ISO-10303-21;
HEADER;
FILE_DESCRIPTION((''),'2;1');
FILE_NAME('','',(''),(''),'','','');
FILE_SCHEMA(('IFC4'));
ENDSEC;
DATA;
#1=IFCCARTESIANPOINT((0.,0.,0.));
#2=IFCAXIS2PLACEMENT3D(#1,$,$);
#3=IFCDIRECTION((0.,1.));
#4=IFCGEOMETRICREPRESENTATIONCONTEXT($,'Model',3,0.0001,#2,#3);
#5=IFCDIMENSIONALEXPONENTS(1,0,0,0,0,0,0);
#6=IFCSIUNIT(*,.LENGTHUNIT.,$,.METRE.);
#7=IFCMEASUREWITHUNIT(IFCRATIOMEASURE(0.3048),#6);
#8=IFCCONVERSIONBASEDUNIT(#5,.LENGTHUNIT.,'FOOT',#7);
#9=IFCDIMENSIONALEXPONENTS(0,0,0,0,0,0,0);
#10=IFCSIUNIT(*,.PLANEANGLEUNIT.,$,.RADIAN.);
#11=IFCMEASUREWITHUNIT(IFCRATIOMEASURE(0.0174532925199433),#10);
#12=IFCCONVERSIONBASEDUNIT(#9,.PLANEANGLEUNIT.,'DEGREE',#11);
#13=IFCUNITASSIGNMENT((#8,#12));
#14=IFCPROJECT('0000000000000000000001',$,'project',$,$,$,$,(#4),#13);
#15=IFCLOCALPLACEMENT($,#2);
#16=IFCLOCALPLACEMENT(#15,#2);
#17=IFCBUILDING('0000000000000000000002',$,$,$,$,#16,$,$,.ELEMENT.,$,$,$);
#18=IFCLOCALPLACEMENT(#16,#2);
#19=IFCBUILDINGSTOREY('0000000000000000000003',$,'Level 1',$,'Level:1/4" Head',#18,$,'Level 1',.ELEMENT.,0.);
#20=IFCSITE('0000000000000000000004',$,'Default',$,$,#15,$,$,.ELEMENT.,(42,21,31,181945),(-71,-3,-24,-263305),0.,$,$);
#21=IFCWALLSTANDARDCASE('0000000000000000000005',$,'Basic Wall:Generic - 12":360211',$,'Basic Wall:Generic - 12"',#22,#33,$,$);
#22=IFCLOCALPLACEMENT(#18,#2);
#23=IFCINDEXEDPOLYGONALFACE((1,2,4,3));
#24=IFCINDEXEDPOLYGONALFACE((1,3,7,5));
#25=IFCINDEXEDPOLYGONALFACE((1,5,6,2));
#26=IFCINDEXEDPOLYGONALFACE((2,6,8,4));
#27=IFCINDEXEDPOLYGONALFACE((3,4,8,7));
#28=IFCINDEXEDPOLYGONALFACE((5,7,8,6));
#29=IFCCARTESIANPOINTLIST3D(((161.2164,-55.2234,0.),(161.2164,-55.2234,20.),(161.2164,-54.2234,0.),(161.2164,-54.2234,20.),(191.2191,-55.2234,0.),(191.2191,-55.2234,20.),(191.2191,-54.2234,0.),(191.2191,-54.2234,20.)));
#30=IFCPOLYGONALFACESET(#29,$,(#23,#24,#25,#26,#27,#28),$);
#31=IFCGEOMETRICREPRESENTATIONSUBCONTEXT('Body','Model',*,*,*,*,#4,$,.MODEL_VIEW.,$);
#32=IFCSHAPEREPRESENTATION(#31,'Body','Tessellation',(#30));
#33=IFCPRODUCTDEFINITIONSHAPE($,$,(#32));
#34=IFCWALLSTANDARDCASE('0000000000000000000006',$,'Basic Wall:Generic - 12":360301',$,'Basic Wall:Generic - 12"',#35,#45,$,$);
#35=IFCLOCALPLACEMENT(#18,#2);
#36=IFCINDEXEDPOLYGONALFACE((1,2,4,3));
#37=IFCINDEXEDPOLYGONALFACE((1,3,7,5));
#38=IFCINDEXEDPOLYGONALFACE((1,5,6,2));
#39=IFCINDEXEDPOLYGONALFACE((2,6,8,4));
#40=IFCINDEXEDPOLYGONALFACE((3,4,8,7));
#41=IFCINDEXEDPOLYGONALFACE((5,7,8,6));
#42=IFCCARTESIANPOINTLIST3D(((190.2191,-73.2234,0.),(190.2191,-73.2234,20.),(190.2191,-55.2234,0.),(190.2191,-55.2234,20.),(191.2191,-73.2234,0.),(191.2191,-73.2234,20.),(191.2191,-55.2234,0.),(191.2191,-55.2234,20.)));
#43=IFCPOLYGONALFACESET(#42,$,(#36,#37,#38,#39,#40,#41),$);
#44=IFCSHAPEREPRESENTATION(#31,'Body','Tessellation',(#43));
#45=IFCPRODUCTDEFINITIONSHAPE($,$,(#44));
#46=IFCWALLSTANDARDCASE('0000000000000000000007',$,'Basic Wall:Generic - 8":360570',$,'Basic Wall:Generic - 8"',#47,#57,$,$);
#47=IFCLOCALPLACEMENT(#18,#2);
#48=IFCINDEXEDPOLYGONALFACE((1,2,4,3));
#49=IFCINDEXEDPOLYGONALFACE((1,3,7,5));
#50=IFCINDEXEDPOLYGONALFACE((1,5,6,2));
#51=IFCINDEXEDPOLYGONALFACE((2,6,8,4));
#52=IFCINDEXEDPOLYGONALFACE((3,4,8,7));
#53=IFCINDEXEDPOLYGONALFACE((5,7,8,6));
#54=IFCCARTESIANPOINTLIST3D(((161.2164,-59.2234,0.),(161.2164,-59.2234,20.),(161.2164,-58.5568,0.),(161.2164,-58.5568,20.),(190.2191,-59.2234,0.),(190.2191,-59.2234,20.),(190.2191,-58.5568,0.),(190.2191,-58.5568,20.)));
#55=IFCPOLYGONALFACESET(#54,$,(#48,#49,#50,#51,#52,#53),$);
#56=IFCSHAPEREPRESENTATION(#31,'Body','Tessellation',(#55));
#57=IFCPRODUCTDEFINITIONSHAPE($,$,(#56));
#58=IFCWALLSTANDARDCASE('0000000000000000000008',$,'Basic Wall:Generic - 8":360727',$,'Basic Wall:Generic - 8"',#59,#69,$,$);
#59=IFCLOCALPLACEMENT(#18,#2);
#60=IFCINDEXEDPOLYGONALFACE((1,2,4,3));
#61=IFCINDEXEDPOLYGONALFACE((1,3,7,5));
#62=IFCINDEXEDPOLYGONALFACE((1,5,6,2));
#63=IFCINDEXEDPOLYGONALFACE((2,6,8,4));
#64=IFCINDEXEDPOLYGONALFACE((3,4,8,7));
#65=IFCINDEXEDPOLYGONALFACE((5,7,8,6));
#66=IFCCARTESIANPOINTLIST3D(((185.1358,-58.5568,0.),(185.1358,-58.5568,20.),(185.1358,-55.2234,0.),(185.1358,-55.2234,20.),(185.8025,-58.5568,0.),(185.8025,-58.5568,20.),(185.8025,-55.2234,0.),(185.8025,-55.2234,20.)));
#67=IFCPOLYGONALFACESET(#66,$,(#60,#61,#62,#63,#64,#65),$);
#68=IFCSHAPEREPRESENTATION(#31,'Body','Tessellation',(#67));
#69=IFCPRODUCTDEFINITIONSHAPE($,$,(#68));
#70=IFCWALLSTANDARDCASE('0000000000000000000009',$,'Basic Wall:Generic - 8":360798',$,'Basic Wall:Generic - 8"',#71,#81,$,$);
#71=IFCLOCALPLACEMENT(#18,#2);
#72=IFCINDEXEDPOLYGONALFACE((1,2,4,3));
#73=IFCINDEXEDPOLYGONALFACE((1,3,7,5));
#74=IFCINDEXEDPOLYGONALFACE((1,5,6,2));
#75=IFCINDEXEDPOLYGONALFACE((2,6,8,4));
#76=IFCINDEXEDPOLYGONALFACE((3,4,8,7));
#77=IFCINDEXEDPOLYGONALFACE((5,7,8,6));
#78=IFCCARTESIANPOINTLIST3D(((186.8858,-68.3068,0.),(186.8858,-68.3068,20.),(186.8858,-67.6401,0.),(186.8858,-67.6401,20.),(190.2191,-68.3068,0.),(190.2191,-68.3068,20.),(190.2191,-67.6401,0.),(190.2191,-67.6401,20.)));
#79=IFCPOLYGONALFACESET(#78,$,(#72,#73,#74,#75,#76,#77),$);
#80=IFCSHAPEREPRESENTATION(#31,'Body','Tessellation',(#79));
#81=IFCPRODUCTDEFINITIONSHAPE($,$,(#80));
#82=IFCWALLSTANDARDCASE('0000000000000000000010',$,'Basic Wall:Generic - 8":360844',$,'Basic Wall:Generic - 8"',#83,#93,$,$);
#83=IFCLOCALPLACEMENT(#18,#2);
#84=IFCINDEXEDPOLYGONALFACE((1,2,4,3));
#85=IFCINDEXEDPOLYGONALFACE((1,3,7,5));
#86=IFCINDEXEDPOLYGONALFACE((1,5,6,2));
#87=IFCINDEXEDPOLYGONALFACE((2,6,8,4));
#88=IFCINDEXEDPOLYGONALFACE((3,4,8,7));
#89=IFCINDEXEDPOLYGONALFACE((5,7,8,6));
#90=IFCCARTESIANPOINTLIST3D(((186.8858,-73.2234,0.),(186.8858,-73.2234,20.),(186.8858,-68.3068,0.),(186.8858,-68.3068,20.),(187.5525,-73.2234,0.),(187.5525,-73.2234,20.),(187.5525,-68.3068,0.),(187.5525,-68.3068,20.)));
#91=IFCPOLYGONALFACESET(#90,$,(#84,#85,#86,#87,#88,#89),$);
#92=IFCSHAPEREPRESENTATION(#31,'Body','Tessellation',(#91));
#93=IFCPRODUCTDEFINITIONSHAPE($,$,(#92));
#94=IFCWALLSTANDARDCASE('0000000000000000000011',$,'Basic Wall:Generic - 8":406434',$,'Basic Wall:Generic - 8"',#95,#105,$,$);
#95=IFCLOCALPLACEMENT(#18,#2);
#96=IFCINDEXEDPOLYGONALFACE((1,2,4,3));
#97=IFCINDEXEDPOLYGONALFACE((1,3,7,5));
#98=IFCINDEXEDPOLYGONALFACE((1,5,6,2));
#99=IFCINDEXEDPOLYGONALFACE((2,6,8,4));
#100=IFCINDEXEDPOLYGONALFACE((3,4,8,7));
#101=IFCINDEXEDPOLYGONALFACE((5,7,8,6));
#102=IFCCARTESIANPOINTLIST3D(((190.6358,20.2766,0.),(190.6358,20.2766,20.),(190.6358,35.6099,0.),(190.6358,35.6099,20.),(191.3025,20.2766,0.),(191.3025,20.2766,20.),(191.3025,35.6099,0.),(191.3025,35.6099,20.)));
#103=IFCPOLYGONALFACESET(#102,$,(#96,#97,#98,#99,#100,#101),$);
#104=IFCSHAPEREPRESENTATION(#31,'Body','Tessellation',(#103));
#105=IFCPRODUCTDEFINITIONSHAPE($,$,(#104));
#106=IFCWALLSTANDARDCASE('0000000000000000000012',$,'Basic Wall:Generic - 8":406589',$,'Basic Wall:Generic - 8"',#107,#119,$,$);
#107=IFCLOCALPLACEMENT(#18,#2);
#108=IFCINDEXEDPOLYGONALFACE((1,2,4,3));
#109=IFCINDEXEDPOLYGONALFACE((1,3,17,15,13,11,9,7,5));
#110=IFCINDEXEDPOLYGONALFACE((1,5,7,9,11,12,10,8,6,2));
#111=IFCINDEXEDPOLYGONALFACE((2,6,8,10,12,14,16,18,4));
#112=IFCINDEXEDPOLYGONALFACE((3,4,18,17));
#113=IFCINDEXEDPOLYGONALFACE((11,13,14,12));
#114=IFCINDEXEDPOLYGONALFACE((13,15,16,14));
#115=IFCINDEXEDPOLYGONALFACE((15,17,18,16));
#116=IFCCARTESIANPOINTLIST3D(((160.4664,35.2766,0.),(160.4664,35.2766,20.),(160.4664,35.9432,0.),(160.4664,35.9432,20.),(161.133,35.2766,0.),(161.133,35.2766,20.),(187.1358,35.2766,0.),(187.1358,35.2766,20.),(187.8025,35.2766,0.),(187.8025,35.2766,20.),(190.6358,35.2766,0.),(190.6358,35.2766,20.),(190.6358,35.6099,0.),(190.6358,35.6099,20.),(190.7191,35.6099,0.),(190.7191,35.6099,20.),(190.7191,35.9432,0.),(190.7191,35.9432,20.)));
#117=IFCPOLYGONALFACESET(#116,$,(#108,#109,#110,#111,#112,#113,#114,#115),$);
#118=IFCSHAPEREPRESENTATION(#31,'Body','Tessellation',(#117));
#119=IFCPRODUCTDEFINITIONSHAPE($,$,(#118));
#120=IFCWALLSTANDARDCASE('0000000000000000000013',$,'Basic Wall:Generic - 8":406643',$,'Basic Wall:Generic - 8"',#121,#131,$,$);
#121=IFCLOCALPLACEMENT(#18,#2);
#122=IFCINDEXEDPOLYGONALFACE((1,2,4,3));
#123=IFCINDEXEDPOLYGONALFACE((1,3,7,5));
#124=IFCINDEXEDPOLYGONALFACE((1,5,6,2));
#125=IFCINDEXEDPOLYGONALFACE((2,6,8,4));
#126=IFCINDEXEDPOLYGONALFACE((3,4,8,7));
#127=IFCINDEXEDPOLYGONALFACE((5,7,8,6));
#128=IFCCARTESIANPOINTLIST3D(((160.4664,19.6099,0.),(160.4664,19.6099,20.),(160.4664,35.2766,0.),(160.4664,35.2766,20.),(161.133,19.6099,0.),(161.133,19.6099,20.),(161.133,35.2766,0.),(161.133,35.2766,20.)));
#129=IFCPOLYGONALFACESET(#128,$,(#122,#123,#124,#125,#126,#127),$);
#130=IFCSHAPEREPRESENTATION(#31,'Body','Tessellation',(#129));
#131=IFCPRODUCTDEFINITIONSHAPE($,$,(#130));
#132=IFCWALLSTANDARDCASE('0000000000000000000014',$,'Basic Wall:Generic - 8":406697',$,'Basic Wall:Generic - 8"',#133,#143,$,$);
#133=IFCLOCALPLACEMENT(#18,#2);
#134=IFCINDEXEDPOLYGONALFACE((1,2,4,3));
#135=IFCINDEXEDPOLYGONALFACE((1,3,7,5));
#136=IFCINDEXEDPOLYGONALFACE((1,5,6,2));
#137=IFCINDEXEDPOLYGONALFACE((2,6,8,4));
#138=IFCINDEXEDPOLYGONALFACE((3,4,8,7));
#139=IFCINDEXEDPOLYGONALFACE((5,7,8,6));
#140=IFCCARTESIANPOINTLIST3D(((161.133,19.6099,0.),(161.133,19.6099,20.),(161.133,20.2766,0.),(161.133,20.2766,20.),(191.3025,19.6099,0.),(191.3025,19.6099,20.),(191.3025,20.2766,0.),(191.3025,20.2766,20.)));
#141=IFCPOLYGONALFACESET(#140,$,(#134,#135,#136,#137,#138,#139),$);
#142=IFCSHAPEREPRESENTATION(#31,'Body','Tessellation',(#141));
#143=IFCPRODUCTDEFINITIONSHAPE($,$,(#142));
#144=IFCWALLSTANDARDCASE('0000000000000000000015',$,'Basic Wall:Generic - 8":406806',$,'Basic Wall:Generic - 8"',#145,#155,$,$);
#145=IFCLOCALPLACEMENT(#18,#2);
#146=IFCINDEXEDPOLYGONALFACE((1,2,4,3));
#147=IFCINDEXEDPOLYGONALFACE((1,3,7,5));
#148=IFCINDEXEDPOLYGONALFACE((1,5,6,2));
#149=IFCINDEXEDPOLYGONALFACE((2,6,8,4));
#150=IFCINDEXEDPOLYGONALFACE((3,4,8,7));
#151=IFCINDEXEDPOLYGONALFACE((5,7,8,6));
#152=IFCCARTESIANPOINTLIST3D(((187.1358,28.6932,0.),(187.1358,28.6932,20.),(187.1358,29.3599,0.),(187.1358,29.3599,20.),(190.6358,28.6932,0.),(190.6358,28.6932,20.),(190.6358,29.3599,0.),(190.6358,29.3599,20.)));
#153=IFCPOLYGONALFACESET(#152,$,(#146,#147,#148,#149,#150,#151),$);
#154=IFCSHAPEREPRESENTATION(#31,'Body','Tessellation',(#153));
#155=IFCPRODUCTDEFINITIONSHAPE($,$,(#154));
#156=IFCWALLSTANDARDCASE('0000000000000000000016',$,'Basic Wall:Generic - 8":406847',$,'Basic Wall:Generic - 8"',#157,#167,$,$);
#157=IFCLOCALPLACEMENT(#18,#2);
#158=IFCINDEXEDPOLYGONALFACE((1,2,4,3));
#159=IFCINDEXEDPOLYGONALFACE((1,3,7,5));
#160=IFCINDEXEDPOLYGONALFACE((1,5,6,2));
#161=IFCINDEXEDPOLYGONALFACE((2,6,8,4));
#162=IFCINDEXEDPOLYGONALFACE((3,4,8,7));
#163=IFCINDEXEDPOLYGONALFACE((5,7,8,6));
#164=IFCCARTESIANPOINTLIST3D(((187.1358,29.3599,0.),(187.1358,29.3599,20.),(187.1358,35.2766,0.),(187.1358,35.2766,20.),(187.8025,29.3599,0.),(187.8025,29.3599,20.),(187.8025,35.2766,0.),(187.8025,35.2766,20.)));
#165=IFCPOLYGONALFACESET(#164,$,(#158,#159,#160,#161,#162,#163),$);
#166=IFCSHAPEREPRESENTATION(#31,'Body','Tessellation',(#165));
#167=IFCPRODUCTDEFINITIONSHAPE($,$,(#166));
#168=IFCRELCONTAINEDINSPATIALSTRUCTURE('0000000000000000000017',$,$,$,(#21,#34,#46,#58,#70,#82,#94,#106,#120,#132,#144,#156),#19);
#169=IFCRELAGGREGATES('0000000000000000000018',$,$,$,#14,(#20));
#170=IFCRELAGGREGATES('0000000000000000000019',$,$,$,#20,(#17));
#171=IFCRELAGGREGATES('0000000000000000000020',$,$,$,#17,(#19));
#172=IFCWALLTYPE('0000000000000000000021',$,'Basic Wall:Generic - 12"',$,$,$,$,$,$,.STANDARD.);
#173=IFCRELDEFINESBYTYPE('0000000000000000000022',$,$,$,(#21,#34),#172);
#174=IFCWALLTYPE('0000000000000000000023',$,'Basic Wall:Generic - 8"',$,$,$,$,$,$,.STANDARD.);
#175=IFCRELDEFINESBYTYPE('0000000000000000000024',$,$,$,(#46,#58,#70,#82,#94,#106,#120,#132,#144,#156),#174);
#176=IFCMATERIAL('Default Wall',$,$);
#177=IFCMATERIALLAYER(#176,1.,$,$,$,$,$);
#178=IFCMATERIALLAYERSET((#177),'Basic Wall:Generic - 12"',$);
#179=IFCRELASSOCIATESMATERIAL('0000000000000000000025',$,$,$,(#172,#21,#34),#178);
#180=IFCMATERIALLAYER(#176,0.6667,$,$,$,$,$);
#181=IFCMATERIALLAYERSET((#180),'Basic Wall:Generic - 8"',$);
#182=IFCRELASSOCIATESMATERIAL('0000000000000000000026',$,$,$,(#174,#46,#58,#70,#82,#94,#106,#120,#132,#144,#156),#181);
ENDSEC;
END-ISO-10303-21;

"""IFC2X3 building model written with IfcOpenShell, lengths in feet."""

from ifc_helpers import new_model, entity, si_unit, converted_unit, direction, frame, frame_2d, origin, place, context, subcontext, project, spatial, polyline, rectangle, outline, extrude, material, layer, layer_set, layer_usage, type_object, element, save


model = new_model("IFC2X3")

# Units and contexts
model_context = context("Model", 3, precision=0.0001, world=origin(), true_north=direction((0.0, 1.0)))
body_context = subcontext(model_context, "Body", "Model", "MODEL_VIEW")
ifc_project = project(units=[converted_unit("LENGTHUNIT", "FOOT", entity("IfcRatioMeasure", 0.3048), si_unit("LENGTHUNIT", "METRE"), dimensions=[1, 0, 0, 0, 0, 0, 0]), converted_unit("PLANEANGLEUNIT", "DEGREE", entity("IfcRatioMeasure", 0.0174532925199433), si_unit("PLANEANGLEUNIT", "RADIAN"), dimensions=[0, 0, 0, 0, 0, 0, 0])], contexts=[model_context])

# Site, building, storey
site_placement = place(None, origin())
site = spatial("IfcSite", under=ifc_project, at=site_placement, Name="Default", CompositionType="ELEMENT", RefLatitude=(42, 21, 31, 181945), RefLongitude=(-71, -3, -24, -263305), RefElevation=0.0)
building_placement = place(site_placement, origin())
building = spatial("IfcBuilding", under=site, at=building_placement, CompositionType="ELEMENT")
storey_placement = place(building_placement, origin())
storey = spatial("IfcBuildingStorey", under=building, at=storey_placement, Name="Level 1", ObjectType="Level:1/4\" Head", LongName="Level 1", CompositionType="ELEMENT", Elevation=0.0)

# Walls
ifc_material = material(Name="Default Wall")
ifc_layer_1 = layer(ifc_material, 1.0)
ifc_layer_set_1 = layer_set([ifc_layer_1], Name="Basic Wall:Generic - 12\"")
ifc_layer_usage_1 = layer_usage(ifc_layer_set_1, "AXIS2", "NEGATIVE", 0.5)
wall_type_1 = type_object("IfcWallType", Name="Basic Wall:Generic - 12\"", PredefinedType="STANDARD", material=ifc_layer_set_1)
wall_1_placement = place(storey_placement, frame((161.2164, -54.7234, 0.0)))
element("IfcWallStandardCase", 1, at=wall_1_placement, inside=storey, type_object=wall_type_1, material=ifc_layer_usage_1, Name="Basic Wall:Generic - 12\":360211", ObjectType="Basic Wall:Generic - 12\"", context=body_context, shape_type="SweptSolid", body=[
    extrude(rectangle(XDim=30.0028, YDim=1.0, at=frame_2d((15.0014, 0.0), x_axis=(-1.0, 0.0))), origin(), (0.0, 0.0, 1.0), 20.0),
])
ifc_layer_usage_2 = layer_usage(ifc_layer_set_1, "AXIS2", "NEGATIVE", 0.5)
wall_2_placement = place(storey_placement, frame((190.7191, -55.2234, 0.0), z_axis=(0.0, 0.0, 1.0), x_axis=(0.0, -1.0, 0.0)))
element("IfcWallStandardCase", 2, at=wall_2_placement, inside=storey, type_object=wall_type_1, material=ifc_layer_usage_2, Name="Basic Wall:Generic - 12\":360301", ObjectType="Basic Wall:Generic - 12\"", context=body_context, shape_type="SweptSolid", body=[
    extrude(rectangle(XDim=18.0, YDim=1.0, at=frame_2d((9.0, 0.0), x_axis=(-1.0, 0.0))), origin(), (0.0, 0.0, 1.0), 20.0),
])
ifc_layer_2 = layer(ifc_material, 0.6667)
ifc_layer_set_2 = layer_set([ifc_layer_2], Name="Basic Wall:Generic - 8\"")
ifc_layer_usage_3 = layer_usage(ifc_layer_set_2, "AXIS2", "NEGATIVE", 0.3333)
wall_type_2 = type_object("IfcWallType", Name="Basic Wall:Generic - 8\"", PredefinedType="STANDARD", material=ifc_layer_set_2)
wall_3_placement = place(storey_placement, frame((161.2164, -58.8901, 0.0)))
element("IfcWallStandardCase", 3, at=wall_3_placement, inside=storey, type_object=wall_type_2, material=ifc_layer_usage_3, Name="Basic Wall:Generic - 8\":360570", ObjectType="Basic Wall:Generic - 8\"", context=body_context, shape_type="SweptSolid", body=[
    extrude(rectangle(XDim=29.0028, YDim=0.6667, at=frame_2d((14.5014, 0.0), x_axis=(-1.0, 0.0))), origin(), (0.0, 0.0, 1.0), 20.0),
])
ifc_layer_usage_4 = layer_usage(ifc_layer_set_2, "AXIS2", "NEGATIVE", 0.3333)
wall_4_placement = place(storey_placement, frame((185.4691, -55.2234, 0.0), z_axis=(0.0, 0.0, 1.0), x_axis=(0.0, -1.0, 0.0)))
element("IfcWallStandardCase", 4, at=wall_4_placement, inside=storey, type_object=wall_type_2, material=ifc_layer_usage_4, Name="Basic Wall:Generic - 8\":360727", ObjectType="Basic Wall:Generic - 8\"", context=body_context, shape_type="SweptSolid", body=[
    extrude(rectangle(XDim=3.3333, YDim=0.6667, at=frame_2d((1.6667, 0.0), x_axis=(-1.0, 0.0))), origin(), (0.0, 0.0, 1.0), 20.0),
])
ifc_layer_usage_5 = layer_usage(ifc_layer_set_2, "AXIS2", "NEGATIVE", 0.3333)
wall_5_placement = place(storey_placement, frame((190.2191, -67.9734, 0.0), z_axis=(0.0, 0.0, 1.0), x_axis=(-1.0, 0.0, 0.0)))
element("IfcWallStandardCase", 5, at=wall_5_placement, inside=storey, type_object=wall_type_2, material=ifc_layer_usage_5, Name="Basic Wall:Generic - 8\":360798", ObjectType="Basic Wall:Generic - 8\"", context=body_context, shape_type="SweptSolid", body=[
    extrude(rectangle(XDim=3.3333, YDim=0.6667, at=frame_2d((1.6667, 0.0), x_axis=(-1.0, 0.0))), origin(), (0.0, 0.0, 1.0), 20.0),
])
ifc_layer_usage_6 = layer_usage(ifc_layer_set_2, "AXIS2", "NEGATIVE", 0.3333)
wall_6_placement = place(storey_placement, frame((187.2191, -68.3068, 0.0), z_axis=(0.0, 0.0, 1.0), x_axis=(0.0, -1.0, 0.0)))
element("IfcWallStandardCase", 6, at=wall_6_placement, inside=storey, type_object=wall_type_2, material=ifc_layer_usage_6, Name="Basic Wall:Generic - 8\":360844", ObjectType="Basic Wall:Generic - 8\"", context=body_context, shape_type="SweptSolid", body=[
    extrude(rectangle(XDim=4.9167, YDim=0.6667, at=frame_2d((2.4583, 0.0), x_axis=(-1.0, 0.0))), origin(), (0.0, 0.0, 1.0), 20.0),
])
ifc_layer_usage_7 = layer_usage(ifc_layer_set_2, "AXIS2", "NEGATIVE", 0.3333)
wall_7_placement = place(storey_placement, frame((190.9691, 20.2766, 0.0), z_axis=(0.0, 0.0, 1.0), x_axis=(0.0, 1.0, 0.0)))
element("IfcWallStandardCase", 7, at=wall_7_placement, inside=storey, type_object=wall_type_2, material=ifc_layer_usage_7, Name="Basic Wall:Generic - 8\":406434", ObjectType="Basic Wall:Generic - 8\"", context=body_context, shape_type="SweptSolid", body=[
    extrude(rectangle(XDim=15.3333, YDim=0.6667, at=frame_2d((7.6667, 0.0), x_axis=(-1.0, 0.0))), origin(), (0.0, 0.0, 1.0), 20.0),
])
ifc_layer_usage_8 = layer_usage(ifc_layer_set_2, "AXIS2", "NEGATIVE", 0.3333)
wall_8_placement = place(storey_placement, frame((190.7191, 35.6099, 0.0), z_axis=(0.0, 0.0, 1.0), x_axis=(-1.0, 0.0, 0.0)))
element("IfcWallStandardCase", 8, at=wall_8_placement, inside=storey, type_object=wall_type_2, material=ifc_layer_usage_8, Name="Basic Wall:Generic - 8\":406589", ObjectType="Basic Wall:Generic - 8\"", context=body_context, shape_type="SweptSolid", body=[
    extrude(outline(polyline([(30.2528, -0.3333), (30.2528, 0.3333), (29.5861, 0.3333), (3.5833, 0.3333), (2.9167, 0.3333), (0.0833, 0.3333), (0.0833, 0.0), (0.0, 0.0), (0.0, -0.3333), (30.2528, -0.3333)])), origin(), (0.0, 0.0, 1.0), 20.0),
])
ifc_layer_usage_9 = layer_usage(ifc_layer_set_2, "AXIS2", "NEGATIVE", 0.3333)
wall_9_placement = place(storey_placement, frame((160.7997, 35.2766, 0.0), z_axis=(0.0, 0.0, 1.0), x_axis=(0.0, -1.0, 0.0)))
element("IfcWallStandardCase", 9, at=wall_9_placement, inside=storey, type_object=wall_type_2, material=ifc_layer_usage_9, Name="Basic Wall:Generic - 8\":406643", ObjectType="Basic Wall:Generic - 8\"", context=body_context, shape_type="SweptSolid", body=[
    extrude(rectangle(XDim=15.6667, YDim=0.6667, at=frame_2d((7.8333, 0.0), x_axis=(-1.0, 0.0))), origin(), (0.0, 0.0, 1.0), 20.0),
])
ifc_layer_usage_10 = layer_usage(ifc_layer_set_2, "AXIS2", "NEGATIVE", 0.3333)
wall_10_placement = place(storey_placement, frame((161.133, 19.9432, 0.0)))
element("IfcWallStandardCase", 10, at=wall_10_placement, inside=storey, type_object=wall_type_2, material=ifc_layer_usage_10, Name="Basic Wall:Generic - 8\":406697", ObjectType="Basic Wall:Generic - 8\"", context=body_context, shape_type="SweptSolid", body=[
    extrude(rectangle(XDim=30.1694, YDim=0.6667, at=frame_2d((15.0847, 0.0), x_axis=(-1.0, 0.0))), origin(), (0.0, 0.0, 1.0), 20.0),
])
ifc_layer_usage_11 = layer_usage(ifc_layer_set_2, "AXIS2", "NEGATIVE", 0.3333)
wall_11_placement = place(storey_placement, frame((190.6358, 29.0266, 0.0), z_axis=(0.0, 0.0, 1.0), x_axis=(-1.0, 0.0, 0.0)))
element("IfcWallStandardCase", 11, at=wall_11_placement, inside=storey, type_object=wall_type_2, material=ifc_layer_usage_11, Name="Basic Wall:Generic - 8\":406806", ObjectType="Basic Wall:Generic - 8\"", context=body_context, shape_type="SweptSolid", body=[
    extrude(rectangle(XDim=3.5, YDim=0.6667, at=frame_2d((1.75, 0.0), x_axis=(-1.0, 0.0))), origin(), (0.0, 0.0, 1.0), 20.0),
])
ifc_layer_usage_12 = layer_usage(ifc_layer_set_2, "AXIS2", "NEGATIVE", 0.3333)
wall_12_placement = place(storey_placement, frame((187.4691, 29.3599, 0.0), z_axis=(0.0, 0.0, 1.0), x_axis=(0.0, 1.0, 0.0)))
element("IfcWallStandardCase", 12, at=wall_12_placement, inside=storey, type_object=wall_type_2, material=ifc_layer_usage_12, Name="Basic Wall:Generic - 8\":406847", ObjectType="Basic Wall:Generic - 8\"", context=body_context, shape_type="SweptSolid", body=[
    extrude(rectangle(XDim=5.9167, YDim=0.6667, at=frame_2d((2.9583, 0.0), x_axis=(-1.0, 0.0))), origin(), (0.0, 0.0, 1.0), 20.0),
])

save(model, "model.ifc")
